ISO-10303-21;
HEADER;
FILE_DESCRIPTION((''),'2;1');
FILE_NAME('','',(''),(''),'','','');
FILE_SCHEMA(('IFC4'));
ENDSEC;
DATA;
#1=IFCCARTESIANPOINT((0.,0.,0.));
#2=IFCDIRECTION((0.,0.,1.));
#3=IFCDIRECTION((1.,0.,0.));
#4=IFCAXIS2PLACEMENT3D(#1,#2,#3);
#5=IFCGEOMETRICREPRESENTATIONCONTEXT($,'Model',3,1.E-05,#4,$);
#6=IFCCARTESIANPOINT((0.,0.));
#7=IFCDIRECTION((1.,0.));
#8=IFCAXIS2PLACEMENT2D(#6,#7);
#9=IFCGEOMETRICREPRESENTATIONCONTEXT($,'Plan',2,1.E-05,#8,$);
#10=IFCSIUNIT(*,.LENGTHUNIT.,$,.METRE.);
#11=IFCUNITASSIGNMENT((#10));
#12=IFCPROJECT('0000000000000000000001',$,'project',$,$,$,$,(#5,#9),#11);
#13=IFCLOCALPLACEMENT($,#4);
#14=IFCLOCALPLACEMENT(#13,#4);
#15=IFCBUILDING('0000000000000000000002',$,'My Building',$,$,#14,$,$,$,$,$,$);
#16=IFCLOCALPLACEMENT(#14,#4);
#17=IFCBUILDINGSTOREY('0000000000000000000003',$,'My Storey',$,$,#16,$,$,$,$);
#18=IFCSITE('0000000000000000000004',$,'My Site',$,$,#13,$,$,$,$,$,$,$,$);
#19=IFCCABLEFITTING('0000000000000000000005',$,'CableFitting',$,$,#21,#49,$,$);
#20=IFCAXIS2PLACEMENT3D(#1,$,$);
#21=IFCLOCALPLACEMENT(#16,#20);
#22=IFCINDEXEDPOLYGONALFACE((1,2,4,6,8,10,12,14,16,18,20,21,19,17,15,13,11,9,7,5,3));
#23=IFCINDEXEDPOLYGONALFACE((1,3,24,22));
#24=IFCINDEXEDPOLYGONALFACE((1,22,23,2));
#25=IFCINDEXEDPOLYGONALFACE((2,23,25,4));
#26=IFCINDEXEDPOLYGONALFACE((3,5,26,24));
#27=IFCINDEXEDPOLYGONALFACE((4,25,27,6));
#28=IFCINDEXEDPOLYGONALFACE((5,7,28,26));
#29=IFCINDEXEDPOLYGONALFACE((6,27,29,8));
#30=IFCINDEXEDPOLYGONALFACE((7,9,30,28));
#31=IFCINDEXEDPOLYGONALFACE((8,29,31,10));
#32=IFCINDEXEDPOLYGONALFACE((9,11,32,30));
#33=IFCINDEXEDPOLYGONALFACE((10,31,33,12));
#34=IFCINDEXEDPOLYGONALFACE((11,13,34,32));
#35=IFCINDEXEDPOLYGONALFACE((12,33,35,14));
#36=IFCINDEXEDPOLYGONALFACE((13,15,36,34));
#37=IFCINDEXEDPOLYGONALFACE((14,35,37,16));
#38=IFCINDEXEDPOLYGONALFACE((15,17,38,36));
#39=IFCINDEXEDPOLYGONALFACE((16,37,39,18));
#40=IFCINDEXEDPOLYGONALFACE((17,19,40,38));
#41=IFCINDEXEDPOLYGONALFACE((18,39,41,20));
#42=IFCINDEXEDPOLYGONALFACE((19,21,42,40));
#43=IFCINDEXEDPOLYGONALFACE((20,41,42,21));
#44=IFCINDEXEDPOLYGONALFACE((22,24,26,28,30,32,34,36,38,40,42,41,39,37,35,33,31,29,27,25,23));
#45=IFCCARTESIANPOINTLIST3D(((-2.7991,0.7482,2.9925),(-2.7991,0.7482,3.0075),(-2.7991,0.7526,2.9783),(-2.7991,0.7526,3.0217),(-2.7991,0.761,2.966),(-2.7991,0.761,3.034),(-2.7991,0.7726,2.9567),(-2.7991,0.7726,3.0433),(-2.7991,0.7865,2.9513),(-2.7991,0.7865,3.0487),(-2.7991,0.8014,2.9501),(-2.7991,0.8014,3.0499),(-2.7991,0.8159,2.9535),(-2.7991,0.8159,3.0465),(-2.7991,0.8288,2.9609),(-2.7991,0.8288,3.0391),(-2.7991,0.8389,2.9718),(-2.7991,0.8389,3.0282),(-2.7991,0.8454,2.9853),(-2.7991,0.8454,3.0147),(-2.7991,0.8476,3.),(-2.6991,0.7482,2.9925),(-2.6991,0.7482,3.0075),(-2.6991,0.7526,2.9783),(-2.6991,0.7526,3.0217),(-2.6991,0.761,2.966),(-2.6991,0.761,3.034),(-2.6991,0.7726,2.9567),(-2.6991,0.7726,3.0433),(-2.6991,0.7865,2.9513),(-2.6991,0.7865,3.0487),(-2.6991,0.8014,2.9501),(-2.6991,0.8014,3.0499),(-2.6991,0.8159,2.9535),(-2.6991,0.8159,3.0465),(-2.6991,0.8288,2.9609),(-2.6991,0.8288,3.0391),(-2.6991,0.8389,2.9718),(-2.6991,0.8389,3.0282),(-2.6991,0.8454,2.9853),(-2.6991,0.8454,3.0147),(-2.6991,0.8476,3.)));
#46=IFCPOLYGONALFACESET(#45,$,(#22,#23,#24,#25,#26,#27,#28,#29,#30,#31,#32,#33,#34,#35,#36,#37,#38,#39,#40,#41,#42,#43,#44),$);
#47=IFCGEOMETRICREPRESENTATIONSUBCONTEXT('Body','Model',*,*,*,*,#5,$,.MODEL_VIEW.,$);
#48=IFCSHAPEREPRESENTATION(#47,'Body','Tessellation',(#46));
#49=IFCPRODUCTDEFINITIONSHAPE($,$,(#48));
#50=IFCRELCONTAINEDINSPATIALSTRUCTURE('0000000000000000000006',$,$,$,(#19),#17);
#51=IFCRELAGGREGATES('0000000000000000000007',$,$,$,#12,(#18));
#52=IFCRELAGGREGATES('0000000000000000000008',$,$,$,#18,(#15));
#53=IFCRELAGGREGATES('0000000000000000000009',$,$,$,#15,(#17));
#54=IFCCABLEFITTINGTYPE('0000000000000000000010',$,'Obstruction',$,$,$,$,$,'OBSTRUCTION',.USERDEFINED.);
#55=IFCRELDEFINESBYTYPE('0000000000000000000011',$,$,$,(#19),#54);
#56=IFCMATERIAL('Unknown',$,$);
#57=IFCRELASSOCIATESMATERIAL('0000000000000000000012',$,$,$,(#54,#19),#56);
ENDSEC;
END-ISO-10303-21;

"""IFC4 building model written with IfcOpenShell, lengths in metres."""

from ifc_helpers import new_model, si_unit, frame, origin_with_axes, origin_2d_with_axis, place, context, subcontext, project, spatial, circle, extrude, material, material_profile, profile_set, profile_usage, type_object, element, save


model = new_model("IFC4")

# Units and contexts
model_context = context("Model", 3, precision=1e-05, world=origin_with_axes())
plan_context = context("Plan", 2, precision=1e-05, world=origin_2d_with_axis())
body_context_1 = subcontext(model_context, "Body", "Model", "MODEL_VIEW")
ifc_project = project(units=[si_unit("LENGTHUNIT", "METRE")], contexts=[model_context, plan_context])

# Site, building, storey
site_placement = place(None, origin_with_axes())
site = spatial("IfcSite", under=ifc_project, at=site_placement, Name="My Site")
building_placement = place(site_placement, origin_with_axes())
building = spatial("IfcBuilding", under=site, at=building_placement, Name="My Building")
storey_placement = place(building_placement, origin_with_axes())
storey = spatial("IfcBuildingStorey", under=building, at=storey_placement, Name="My Storey")

# Shared definitions
ifc_material = material(Name="Unknown")

# Cable fitting
ifc_material_profile_1 = material_profile(ifc_material, circle(Radius=0.05))
ifc_profile_set_1 = profile_set([ifc_material_profile_1])
ifc_profile_usage_1 = profile_usage(ifc_profile_set_1, cardinal=5)
cable_fitting_type_1 = type_object("IfcCableFittingType", Name="Obstruction", ElementType="OBSTRUCTION", PredefinedType="USERDEFINED", material=ifc_profile_set_1)
cable_fitting_1_placement = place(storey_placement, frame((-2.7991, 0.7976, 3.0), z_axis=(1.0, -0.000001, 0.000001), x_axis=(0.000001, 1.0, 0.0)))
element("IfcCableFitting", 1, at=cable_fitting_1_placement, inside=storey, type_object=cable_fitting_type_1, material=ifc_profile_usage_1, Name="CableFitting", context=body_context_1, shape_type="SweptSolid", body=[
    extrude(circle(Radius=0.05), origin_with_axes(), (0.0, 0.0, 1.0), 0.1),
])

save(model, "model.ifc")
